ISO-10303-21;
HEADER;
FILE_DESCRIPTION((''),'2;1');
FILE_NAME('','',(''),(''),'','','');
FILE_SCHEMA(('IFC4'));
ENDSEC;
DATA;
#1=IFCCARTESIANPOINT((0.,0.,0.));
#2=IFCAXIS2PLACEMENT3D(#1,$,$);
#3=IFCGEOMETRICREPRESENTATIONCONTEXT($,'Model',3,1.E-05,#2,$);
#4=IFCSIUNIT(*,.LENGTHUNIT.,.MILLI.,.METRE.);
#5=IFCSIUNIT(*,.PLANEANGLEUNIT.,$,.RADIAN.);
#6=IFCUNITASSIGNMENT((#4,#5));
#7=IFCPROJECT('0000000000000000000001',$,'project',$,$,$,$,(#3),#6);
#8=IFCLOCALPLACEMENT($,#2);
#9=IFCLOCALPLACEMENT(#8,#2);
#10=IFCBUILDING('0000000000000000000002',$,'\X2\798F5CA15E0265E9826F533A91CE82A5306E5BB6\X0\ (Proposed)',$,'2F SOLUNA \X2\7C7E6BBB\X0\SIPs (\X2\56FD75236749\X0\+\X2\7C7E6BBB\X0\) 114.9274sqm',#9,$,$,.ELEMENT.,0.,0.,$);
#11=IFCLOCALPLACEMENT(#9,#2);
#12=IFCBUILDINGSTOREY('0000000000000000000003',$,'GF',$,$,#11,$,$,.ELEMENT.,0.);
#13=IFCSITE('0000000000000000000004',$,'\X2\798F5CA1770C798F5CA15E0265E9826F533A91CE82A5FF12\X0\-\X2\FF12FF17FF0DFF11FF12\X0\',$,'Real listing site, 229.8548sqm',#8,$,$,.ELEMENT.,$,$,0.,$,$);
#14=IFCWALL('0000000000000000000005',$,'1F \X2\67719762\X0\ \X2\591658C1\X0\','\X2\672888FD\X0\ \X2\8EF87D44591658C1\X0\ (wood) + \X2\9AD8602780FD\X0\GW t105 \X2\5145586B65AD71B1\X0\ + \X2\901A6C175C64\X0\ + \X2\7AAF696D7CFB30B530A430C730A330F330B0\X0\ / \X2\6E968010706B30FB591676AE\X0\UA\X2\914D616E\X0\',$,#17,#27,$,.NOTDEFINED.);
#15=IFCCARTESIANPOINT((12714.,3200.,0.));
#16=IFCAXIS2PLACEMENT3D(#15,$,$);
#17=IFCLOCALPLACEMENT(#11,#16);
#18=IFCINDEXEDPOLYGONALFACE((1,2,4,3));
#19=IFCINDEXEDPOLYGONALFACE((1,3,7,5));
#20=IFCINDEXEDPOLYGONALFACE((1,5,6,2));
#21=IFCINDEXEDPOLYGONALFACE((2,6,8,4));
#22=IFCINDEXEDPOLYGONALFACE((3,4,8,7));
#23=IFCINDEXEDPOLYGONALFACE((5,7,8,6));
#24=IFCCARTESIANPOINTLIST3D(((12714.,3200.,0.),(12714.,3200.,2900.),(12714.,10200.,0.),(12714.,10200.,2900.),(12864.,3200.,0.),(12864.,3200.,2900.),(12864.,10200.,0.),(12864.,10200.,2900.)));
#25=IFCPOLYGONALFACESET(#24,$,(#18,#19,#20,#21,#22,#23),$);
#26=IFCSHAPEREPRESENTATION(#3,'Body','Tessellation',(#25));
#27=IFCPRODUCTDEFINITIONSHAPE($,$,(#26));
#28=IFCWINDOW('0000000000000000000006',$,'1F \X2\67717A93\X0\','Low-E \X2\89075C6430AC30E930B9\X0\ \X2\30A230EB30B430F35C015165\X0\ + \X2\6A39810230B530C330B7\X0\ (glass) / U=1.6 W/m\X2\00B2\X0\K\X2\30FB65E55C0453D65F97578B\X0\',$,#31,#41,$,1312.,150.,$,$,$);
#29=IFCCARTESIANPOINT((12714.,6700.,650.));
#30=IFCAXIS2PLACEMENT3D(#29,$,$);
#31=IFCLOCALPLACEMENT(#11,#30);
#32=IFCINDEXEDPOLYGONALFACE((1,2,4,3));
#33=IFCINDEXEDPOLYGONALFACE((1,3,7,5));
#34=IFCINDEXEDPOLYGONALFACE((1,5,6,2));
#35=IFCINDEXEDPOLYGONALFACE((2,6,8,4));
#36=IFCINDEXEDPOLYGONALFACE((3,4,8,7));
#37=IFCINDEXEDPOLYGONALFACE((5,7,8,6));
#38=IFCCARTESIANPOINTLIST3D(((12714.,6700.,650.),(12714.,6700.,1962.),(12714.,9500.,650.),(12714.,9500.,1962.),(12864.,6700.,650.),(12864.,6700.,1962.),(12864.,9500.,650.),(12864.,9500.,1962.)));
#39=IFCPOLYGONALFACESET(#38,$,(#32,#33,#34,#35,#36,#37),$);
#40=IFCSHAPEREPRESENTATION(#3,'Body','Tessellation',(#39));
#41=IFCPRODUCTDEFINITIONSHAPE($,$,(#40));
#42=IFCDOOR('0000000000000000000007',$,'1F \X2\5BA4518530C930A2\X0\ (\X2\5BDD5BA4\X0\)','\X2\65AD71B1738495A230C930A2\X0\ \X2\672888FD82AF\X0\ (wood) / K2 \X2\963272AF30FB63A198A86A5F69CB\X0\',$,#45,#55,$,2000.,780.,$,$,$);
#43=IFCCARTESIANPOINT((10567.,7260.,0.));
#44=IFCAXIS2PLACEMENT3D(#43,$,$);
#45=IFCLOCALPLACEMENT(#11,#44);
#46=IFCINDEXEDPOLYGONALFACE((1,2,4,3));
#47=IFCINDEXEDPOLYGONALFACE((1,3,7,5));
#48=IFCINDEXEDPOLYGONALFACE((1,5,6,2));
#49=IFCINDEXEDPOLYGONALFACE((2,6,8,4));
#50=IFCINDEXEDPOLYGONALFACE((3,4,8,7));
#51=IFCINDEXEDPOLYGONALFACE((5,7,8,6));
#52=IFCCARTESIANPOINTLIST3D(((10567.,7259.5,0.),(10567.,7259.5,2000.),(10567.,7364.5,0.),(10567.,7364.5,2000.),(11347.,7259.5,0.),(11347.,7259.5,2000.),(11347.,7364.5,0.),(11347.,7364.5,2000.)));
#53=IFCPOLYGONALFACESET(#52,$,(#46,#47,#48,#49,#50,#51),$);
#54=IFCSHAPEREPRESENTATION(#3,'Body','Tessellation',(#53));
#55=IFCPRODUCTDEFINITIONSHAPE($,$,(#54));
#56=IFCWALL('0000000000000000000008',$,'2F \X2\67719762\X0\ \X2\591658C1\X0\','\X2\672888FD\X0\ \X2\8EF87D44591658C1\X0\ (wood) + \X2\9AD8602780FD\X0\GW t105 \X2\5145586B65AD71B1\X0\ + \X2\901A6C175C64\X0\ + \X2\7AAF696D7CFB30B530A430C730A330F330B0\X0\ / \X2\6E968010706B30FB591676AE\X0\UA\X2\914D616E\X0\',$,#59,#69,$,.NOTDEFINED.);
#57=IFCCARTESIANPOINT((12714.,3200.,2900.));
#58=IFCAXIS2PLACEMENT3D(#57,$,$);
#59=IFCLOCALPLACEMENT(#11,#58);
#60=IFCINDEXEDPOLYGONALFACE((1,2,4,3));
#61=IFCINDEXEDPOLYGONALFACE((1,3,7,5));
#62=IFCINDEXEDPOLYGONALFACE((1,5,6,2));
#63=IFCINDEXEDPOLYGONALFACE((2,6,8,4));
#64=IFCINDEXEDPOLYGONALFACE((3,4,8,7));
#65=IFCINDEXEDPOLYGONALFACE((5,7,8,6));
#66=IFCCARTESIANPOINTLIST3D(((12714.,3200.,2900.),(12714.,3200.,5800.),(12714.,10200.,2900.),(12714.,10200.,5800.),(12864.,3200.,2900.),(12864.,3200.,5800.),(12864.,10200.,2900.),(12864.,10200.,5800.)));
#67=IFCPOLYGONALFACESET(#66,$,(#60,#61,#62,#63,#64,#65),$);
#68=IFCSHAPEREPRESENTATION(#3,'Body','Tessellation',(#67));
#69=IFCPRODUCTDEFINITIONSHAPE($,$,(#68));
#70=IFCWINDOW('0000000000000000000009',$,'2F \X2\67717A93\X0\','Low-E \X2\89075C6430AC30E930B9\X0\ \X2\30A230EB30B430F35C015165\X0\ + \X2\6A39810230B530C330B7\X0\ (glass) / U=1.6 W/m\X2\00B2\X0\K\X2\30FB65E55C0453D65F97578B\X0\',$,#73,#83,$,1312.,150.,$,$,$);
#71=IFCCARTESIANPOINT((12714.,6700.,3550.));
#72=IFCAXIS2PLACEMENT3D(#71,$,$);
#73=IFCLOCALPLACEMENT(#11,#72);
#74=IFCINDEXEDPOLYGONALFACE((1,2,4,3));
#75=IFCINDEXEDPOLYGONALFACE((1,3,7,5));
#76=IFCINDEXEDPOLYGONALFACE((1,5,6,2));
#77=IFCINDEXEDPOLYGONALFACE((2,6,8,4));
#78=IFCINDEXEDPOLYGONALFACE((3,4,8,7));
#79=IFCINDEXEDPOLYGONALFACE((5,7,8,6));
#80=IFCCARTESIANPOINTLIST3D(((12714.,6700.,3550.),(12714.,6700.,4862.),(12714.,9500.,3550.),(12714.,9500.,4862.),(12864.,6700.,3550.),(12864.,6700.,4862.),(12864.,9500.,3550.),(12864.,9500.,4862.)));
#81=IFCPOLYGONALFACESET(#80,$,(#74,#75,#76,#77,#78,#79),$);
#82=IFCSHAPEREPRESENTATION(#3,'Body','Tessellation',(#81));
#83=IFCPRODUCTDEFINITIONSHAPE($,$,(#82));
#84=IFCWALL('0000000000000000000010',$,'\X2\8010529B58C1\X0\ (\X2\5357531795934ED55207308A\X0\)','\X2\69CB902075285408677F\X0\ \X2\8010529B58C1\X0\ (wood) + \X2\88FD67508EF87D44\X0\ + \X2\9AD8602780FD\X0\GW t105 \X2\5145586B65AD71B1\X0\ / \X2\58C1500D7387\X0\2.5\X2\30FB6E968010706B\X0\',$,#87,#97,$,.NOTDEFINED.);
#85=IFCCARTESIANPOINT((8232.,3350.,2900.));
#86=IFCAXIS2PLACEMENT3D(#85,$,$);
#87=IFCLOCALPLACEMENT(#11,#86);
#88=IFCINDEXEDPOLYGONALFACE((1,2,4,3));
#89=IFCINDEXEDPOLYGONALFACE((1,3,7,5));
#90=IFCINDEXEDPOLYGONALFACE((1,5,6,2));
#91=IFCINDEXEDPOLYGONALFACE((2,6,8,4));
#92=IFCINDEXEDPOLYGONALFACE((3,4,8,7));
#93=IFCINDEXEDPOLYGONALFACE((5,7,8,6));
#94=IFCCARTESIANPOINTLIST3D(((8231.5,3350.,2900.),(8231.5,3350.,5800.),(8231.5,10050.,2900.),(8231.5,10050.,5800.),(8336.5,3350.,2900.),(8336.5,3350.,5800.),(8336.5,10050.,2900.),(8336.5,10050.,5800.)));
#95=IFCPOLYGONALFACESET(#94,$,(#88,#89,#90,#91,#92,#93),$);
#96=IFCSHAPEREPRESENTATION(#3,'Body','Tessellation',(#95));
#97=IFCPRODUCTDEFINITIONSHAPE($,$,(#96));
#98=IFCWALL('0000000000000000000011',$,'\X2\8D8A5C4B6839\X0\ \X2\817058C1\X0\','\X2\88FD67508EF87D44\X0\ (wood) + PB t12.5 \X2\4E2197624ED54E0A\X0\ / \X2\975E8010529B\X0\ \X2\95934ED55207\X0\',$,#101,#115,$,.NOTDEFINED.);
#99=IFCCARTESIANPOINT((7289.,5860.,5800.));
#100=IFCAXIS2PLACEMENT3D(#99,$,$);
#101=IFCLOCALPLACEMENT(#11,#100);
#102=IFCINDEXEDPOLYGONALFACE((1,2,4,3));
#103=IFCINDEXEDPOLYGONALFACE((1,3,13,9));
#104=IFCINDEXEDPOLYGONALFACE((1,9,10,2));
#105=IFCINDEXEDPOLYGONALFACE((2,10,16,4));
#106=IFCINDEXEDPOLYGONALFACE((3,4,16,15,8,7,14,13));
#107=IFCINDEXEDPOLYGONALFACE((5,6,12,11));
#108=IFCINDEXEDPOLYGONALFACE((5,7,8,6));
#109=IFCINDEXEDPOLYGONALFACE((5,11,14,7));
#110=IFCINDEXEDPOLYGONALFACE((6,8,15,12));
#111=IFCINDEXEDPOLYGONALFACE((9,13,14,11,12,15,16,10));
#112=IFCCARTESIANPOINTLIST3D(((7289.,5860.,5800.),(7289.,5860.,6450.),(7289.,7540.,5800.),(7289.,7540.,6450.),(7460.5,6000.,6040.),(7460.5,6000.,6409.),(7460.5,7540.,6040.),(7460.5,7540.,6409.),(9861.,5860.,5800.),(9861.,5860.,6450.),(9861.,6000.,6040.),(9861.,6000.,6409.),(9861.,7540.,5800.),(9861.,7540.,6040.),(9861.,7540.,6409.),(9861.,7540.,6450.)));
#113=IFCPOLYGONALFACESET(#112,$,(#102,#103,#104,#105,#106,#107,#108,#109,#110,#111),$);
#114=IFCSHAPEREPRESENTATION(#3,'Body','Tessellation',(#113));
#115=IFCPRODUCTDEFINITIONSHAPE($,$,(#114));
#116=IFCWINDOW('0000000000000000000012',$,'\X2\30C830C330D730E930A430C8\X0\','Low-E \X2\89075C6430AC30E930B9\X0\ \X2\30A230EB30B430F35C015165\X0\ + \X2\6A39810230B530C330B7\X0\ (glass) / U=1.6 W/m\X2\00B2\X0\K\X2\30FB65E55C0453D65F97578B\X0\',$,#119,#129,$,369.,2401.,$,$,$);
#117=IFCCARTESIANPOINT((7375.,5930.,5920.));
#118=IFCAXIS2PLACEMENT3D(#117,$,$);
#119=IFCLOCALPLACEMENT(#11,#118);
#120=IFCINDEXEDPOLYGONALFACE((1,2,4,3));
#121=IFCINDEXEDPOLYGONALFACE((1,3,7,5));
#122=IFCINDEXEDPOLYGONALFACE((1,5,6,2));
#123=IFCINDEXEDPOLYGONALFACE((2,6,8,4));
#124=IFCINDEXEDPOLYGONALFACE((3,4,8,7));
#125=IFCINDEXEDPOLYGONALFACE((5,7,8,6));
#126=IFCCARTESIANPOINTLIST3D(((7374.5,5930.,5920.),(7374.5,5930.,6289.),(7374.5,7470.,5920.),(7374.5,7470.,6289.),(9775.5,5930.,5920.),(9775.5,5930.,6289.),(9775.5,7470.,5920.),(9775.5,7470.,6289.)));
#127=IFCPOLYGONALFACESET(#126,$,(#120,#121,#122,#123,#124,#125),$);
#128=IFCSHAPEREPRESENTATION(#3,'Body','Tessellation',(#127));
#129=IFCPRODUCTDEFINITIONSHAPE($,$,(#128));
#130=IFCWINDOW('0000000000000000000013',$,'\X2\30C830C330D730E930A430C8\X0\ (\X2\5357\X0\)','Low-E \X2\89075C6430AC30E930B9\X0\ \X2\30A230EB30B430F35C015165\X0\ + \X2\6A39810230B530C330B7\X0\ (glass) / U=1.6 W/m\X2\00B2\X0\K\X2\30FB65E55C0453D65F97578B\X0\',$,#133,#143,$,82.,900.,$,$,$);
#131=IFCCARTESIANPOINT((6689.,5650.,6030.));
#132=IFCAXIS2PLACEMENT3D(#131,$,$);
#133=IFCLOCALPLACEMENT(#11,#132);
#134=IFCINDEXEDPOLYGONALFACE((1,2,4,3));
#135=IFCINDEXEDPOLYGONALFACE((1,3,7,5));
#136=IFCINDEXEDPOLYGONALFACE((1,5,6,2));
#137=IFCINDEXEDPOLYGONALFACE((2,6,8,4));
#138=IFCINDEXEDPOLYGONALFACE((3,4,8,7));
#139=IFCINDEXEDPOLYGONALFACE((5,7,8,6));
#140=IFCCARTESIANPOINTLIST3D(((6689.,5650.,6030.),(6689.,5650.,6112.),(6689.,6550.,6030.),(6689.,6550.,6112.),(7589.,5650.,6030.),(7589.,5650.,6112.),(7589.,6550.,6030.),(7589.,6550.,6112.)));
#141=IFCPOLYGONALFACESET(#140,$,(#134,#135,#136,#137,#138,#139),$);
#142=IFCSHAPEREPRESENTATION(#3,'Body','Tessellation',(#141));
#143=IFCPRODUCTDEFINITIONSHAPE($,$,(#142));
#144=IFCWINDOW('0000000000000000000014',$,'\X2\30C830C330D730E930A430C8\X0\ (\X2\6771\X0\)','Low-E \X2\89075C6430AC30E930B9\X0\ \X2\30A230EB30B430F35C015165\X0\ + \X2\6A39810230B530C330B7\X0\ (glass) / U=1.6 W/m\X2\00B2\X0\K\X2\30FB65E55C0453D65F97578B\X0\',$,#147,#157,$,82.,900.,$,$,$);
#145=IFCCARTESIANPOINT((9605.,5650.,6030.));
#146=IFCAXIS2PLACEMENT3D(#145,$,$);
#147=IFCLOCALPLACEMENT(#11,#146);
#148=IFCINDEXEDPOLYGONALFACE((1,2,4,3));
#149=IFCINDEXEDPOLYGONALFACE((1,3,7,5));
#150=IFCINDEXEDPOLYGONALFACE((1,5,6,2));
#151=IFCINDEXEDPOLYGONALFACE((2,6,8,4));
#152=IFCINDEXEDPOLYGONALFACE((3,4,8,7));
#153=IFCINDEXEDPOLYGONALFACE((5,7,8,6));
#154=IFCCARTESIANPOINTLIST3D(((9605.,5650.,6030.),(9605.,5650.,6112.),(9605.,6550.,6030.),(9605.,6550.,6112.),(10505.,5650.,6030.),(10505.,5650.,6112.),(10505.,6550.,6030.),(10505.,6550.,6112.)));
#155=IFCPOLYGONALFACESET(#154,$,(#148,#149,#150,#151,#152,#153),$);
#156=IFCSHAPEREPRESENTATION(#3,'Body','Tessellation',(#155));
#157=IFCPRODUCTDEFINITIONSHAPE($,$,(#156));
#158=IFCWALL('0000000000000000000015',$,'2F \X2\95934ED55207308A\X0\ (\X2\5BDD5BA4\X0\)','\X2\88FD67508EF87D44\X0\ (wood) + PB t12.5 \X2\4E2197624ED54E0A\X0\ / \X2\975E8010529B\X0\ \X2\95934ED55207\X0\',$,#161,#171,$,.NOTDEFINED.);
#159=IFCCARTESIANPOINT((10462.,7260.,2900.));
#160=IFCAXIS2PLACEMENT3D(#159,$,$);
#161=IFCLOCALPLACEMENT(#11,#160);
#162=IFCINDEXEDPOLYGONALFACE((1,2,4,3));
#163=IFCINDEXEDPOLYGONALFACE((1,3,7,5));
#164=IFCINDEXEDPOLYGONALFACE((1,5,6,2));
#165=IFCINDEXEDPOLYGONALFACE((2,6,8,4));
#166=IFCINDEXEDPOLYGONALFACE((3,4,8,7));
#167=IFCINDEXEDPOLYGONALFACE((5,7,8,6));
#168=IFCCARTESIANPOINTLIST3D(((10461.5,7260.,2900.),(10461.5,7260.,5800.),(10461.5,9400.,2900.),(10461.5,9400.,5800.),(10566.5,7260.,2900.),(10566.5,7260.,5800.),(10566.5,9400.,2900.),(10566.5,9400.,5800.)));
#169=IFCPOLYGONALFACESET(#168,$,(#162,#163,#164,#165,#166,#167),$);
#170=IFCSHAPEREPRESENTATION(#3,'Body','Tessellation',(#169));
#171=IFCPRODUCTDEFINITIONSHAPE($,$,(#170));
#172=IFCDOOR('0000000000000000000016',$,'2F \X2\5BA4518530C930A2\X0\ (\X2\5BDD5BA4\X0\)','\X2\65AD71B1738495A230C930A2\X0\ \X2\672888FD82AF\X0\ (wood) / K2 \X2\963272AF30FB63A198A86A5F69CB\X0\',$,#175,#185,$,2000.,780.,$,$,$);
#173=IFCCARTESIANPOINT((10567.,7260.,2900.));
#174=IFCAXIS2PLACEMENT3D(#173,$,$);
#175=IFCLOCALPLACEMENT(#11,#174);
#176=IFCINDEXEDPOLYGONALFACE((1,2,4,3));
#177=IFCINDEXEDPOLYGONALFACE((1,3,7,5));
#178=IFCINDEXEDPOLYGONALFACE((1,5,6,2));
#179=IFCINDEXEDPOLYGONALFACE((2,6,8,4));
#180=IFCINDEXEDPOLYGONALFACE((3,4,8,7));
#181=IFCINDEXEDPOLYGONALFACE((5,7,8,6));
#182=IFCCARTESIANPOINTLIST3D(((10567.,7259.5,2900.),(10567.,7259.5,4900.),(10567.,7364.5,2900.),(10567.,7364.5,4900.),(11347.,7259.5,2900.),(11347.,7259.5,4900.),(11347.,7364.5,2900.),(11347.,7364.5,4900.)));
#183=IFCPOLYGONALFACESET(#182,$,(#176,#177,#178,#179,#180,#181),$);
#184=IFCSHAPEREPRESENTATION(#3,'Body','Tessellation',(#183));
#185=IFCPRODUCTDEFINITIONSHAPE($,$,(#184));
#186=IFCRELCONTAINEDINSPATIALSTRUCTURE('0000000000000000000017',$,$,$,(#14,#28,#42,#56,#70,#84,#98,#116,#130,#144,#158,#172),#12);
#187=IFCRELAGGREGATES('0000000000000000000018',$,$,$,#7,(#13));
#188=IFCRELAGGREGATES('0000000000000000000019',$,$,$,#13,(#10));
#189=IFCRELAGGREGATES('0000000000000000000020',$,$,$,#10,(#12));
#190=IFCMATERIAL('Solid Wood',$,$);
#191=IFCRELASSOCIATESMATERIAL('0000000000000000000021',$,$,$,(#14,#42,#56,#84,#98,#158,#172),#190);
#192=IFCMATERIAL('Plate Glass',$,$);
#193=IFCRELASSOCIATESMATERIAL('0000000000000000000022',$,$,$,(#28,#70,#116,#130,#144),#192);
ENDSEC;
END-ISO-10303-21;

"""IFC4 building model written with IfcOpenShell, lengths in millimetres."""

from ifc_helpers import new_model, si_unit, frame, frame_2d, origin, place, context, project, spatial, rectangle, extrude, material, element, fill, save


model = new_model("IFC4")

# Units and contexts
model_context = context("Model", 3, precision=1e-05, world=origin())
ifc_project = project(units=[si_unit("LENGTHUNIT", "METRE", prefix="MILLI"), si_unit("PLANEANGLEUNIT", "RADIAN")], contexts=[model_context])

# Site, building, storey
site_placement = place(None, origin())
site = spatial("IfcSite", under=ifc_project, at=site_placement, Name="福岡県福岡市早良区野芥２-２７－１２", ObjectType="Real listing site, 229.8548sqm", CompositionType="ELEMENT", RefElevation=0.0)
building_placement = place(site_placement, origin())
building = spatial("IfcBuilding", under=site, at=building_placement, Name="福岡市早良区野芥の家 (Proposed)", ObjectType="2F SOLUNA 籾殻SIPs (国産杉+籾殻) 114.9274sqm", CompositionType="ELEMENT", ElevationOfRefHeight=0.0, ElevationOfTerrain=0.0)
storey_placement = place(building_placement, origin())
storey = spatial("IfcBuildingStorey", under=building, at=storey_placement, Name="GF", CompositionType="ELEMENT", Elevation=0.0)

# Wall, opening, window
ifc_material_1 = material(Name="Solid Wood")
wall_1_placement = place(storey_placement, frame((12714.0, 3200.0, 0.0)))
wall_1 = element("IfcWall", 1, at=wall_1_placement, inside=storey, material=ifc_material_1, Name="1F 東面 外壁", Description="木製 軸組外壁 (wood) + 高性能GW t105 充填断熱 + 通気層 + 窯業系サイディング / 準耐火・外皮UA配慮", PredefinedType="NOTDEFINED", context=model_context, shape_type="SweptSolid", body=[
    extrude(rectangle(XDim=150.0, YDim=7000.0, at=frame_2d((75.0, 3500.0))), frame((12714.0, 3200.0, 0.0)), (0.0, 0.0, 1.0), 2900.0),
])
opening_1_placement = place(storey_placement, frame((12714.0, 6700.0, 650.0)))
opening_1 = element("IfcOpeningElement", 2, at=opening_1_placement, cuts=wall_1, PredefinedType="NOTDEFINED", context=model_context, shape_type="SweptSolid", body=[
    extrude(rectangle(XDim=150.0, YDim=2800.0, at=frame_2d((75.0, 1400.0))), frame((12714.0, 6700.0, 650.0)), (0.0, 0.0, 1.0), 1312.0),
])
ifc_material_2 = material(Name="Plate Glass")
window_1_placement = place(storey_placement, frame((12714.0, 6700.0, 650.0)))
window_1 = element("IfcWindow", 3, at=window_1_placement, inside=storey, material=ifc_material_2, Name="1F 東窓", Description="Low-E 複層ガラス アルゴン封入 + 樹脂サッシ (glass) / U=1.6 W/m²K・日射取得型", OverallHeight=1312.0, OverallWidth=150.0, context=model_context, shape_type="SweptSolid", body=[
    extrude(rectangle(XDim=150.0, YDim=2800.0, at=frame_2d((75.0, 1400.0))), frame((12714.0, 6700.0, 650.0)), (0.0, 0.0, 1.0), 1312.0),
])
fill(opening_1, window_1)

# Door
door_1_placement = place(storey_placement, frame((10567.0, 7260.0, 0.0)))
element("IfcDoor", 4, at=door_1_placement, inside=storey, material=ifc_material_1, Name="1F 室内ドア (寝室)", Description="断熱玄関ドア 木製芯 (wood) / K2 防犯・採風機構", OverallHeight=2000.0, OverallWidth=780.0, context=model_context, shape_type="SweptSolid", body=[
    extrude(rectangle(XDim=780.0, YDim=105.0, at=frame_2d((390.0, 52.0))), frame((10567.0, 7260.0, 0.0)), (0.0, 0.0, 1.0), 2000.0),
])

# Wall, opening, window
wall_2_placement = place(storey_placement, frame((12714.0, 3200.0, 2900.0)))
wall_2 = element("IfcWall", 5, at=wall_2_placement, inside=storey, material=ifc_material_1, Name="2F 東面 外壁", Description="木製 軸組外壁 (wood) + 高性能GW t105 充填断熱 + 通気層 + 窯業系サイディング / 準耐火・外皮UA配慮", PredefinedType="NOTDEFINED", context=model_context, shape_type="SweptSolid", body=[
    extrude(rectangle(XDim=150.0, YDim=7000.0, at=frame_2d((75.0, 3500.0))), frame((12714.0, 3200.0, 2900.0)), (0.0, 0.0, 1.0), 2900.0),
])
opening_2_placement = place(storey_placement, frame((12714.0, 6700.0, 3550.0)))
opening_2 = element("IfcOpeningElement", 6, at=opening_2_placement, cuts=wall_2, PredefinedType="NOTDEFINED", context=model_context, shape_type="SweptSolid", body=[
    extrude(rectangle(XDim=150.0, YDim=2800.0, at=frame_2d((75.0, 1400.0))), frame((12714.0, 6700.0, 3550.0)), (0.0, 0.0, 1.0), 1312.0),
])
window_2_placement = place(storey_placement, frame((12714.0, 6700.0, 3550.0)))
window_2 = element("IfcWindow", 7, at=window_2_placement, inside=storey, material=ifc_material_2, Name="2F 東窓", Description="Low-E 複層ガラス アルゴン封入 + 樹脂サッシ (glass) / U=1.6 W/m²K・日射取得型", OverallHeight=1312.0, OverallWidth=150.0, context=model_context, shape_type="SweptSolid", body=[
    extrude(rectangle(XDim=150.0, YDim=2800.0, at=frame_2d((75.0, 1400.0))), frame((12714.0, 6700.0, 3550.0)), (0.0, 0.0, 1.0), 1312.0),
])
fill(opening_2, window_2)

# Wall
wall_3_placement = place(storey_placement, frame((8232.0, 3350.0, 2900.0)))
element("IfcWall", 8, at=wall_3_placement, inside=storey, material=ifc_material_1, Name="耐力壁 (南北間仕切り)", Description="構造用合板 耐力壁 (wood) + 製材軸組 + 高性能GW t105 充填断熱 / 壁倍率2.5・準耐火", PredefinedType="NOTDEFINED", context=model_context, shape_type="SweptSolid", body=[
    extrude(rectangle(XDim=105.0, YDim=6700.0, at=frame_2d((52.0, 3350.0))), frame((8232.0, 3350.0, 2900.0)), (0.0, 0.0, 1.0), 2900.0),
])

# Wall, openings, windows
wall_4_placement = place(storey_placement, frame((7289.0, 5860.0, 5800.0)))
wall_4 = element("IfcWall", 9, at=wall_4_placement, inside=storey, material=ifc_material_1, Name="越屋根 腰壁", Description="製材軸組 (wood) + PB t12.5 両面仕上 / 非耐力 間仕切", PredefinedType="NOTDEFINED", context=model_context, shape_type="SweptSolid", body=[
    extrude(rectangle(XDim=2572.0, YDim=1680.0, at=frame_2d((1286.0, 840.0))), frame((7289.0, 5860.0, 5800.0)), (0.0, 0.0, 1.0), 650.0),
])
opening_3_placement = place(storey_placement, frame((7375.0, 5930.0, 5920.0)))
opening_3 = element("IfcOpeningElement", 10, at=opening_3_placement, cuts=wall_4, PredefinedType="NOTDEFINED", context=model_context, shape_type="SweptSolid", body=[
    extrude(rectangle(XDim=2401.0, YDim=1540.0, at=frame_2d((1200.0, 770.0))), frame((7375.0, 5930.0, 5920.0)), (0.0, 0.0, 1.0), 369.0),
])
opening_4_placement = place(storey_placement, frame((6689.0, 5650.0, 6030.0)))
opening_4 = element("IfcOpeningElement", 11, at=opening_4_placement, cuts=wall_4, PredefinedType="NOTDEFINED", context=model_context, shape_type="SweptSolid", body=[
    extrude(rectangle(XDim=900.0, YDim=900.0, at=frame_2d((450.0, 450.0))), frame((6689.0, 5650.0, 6030.0)), (0.0, 0.0, 1.0), 82.0),
])
opening_5_placement = place(storey_placement, frame((9605.0, 5650.0, 6030.0)))
opening_5 = element("IfcOpeningElement", 12, at=opening_5_placement, cuts=wall_4, PredefinedType="NOTDEFINED", context=model_context, shape_type="SweptSolid", body=[
    extrude(rectangle(XDim=900.0, YDim=900.0, at=frame_2d((450.0, 450.0))), frame((9605.0, 5650.0, 6030.0)), (0.0, 0.0, 1.0), 82.0),
])
window_3_placement = place(storey_placement, frame((7375.0, 5930.0, 5920.0)))
window_3 = element("IfcWindow", 13, at=window_3_placement, inside=storey, material=ifc_material_2, Name="トップライト", Description="Low-E 複層ガラス アルゴン封入 + 樹脂サッシ (glass) / U=1.6 W/m²K・日射取得型", OverallHeight=369.0, OverallWidth=2401.0, context=model_context, shape_type="SweptSolid", body=[
    extrude(rectangle(XDim=2401.0, YDim=1540.0, at=frame_2d((1200.0, 770.0))), frame((7375.0, 5930.0, 5920.0)), (0.0, 0.0, 1.0), 369.0),
])
fill(opening_3, window_3)
window_4_placement = place(storey_placement, frame((6689.0, 5650.0, 6030.0)))
window_4 = element("IfcWindow", 14, at=window_4_placement, inside=storey, material=ifc_material_2, Name="トップライト (南)", Description="Low-E 複層ガラス アルゴン封入 + 樹脂サッシ (glass) / U=1.6 W/m²K・日射取得型", OverallHeight=82.0, OverallWidth=900.0, context=model_context, shape_type="SweptSolid", body=[
    extrude(rectangle(XDim=900.0, YDim=900.0, at=frame_2d((450.0, 450.0))), frame((6689.0, 5650.0, 6030.0)), (0.0, 0.0, 1.0), 82.0),
])
fill(opening_4, window_4)
window_5_placement = place(storey_placement, frame((9605.0, 5650.0, 6030.0)))
window_5 = element("IfcWindow", 15, at=window_5_placement, inside=storey, material=ifc_material_2, Name="トップライト (東)", Description="Low-E 複層ガラス アルゴン封入 + 樹脂サッシ (glass) / U=1.6 W/m²K・日射取得型", OverallHeight=82.0, OverallWidth=900.0, context=model_context, shape_type="SweptSolid", body=[
    extrude(rectangle(XDim=900.0, YDim=900.0, at=frame_2d((450.0, 450.0))), frame((9605.0, 5650.0, 6030.0)), (0.0, 0.0, 1.0), 82.0),
])
fill(opening_5, window_5)

# Wall
wall_5_placement = place(storey_placement, frame((10462.0, 7260.0, 2900.0)))
element("IfcWall", 16, at=wall_5_placement, inside=storey, material=ifc_material_1, Name="2F 間仕切り (寝室)", Description="製材軸組 (wood) + PB t12.5 両面仕上 / 非耐力 間仕切", PredefinedType="NOTDEFINED", context=model_context, shape_type="SweptSolid", body=[
    extrude(rectangle(XDim=105.0, YDim=2140.0, at=frame_2d((52.0, 1070.0))), frame((10462.0, 7260.0, 2900.0)), (0.0, 0.0, 1.0), 2900.0),
])

# Door
door_2_placement = place(storey_placement, frame((10567.0, 7260.0, 2900.0)))
element("IfcDoor", 17, at=door_2_placement, inside=storey, material=ifc_material_1, Name="2F 室内ドア (寝室)", Description="断熱玄関ドア 木製芯 (wood) / K2 防犯・採風機構", OverallHeight=2000.0, OverallWidth=780.0, context=model_context, shape_type="SweptSolid", body=[
    extrude(rectangle(XDim=780.0, YDim=105.0, at=frame_2d((390.0, 52.0))), frame((10567.0, 7260.0, 2900.0)), (0.0, 0.0, 1.0), 2000.0),
])

save(model, "model.ifc")
